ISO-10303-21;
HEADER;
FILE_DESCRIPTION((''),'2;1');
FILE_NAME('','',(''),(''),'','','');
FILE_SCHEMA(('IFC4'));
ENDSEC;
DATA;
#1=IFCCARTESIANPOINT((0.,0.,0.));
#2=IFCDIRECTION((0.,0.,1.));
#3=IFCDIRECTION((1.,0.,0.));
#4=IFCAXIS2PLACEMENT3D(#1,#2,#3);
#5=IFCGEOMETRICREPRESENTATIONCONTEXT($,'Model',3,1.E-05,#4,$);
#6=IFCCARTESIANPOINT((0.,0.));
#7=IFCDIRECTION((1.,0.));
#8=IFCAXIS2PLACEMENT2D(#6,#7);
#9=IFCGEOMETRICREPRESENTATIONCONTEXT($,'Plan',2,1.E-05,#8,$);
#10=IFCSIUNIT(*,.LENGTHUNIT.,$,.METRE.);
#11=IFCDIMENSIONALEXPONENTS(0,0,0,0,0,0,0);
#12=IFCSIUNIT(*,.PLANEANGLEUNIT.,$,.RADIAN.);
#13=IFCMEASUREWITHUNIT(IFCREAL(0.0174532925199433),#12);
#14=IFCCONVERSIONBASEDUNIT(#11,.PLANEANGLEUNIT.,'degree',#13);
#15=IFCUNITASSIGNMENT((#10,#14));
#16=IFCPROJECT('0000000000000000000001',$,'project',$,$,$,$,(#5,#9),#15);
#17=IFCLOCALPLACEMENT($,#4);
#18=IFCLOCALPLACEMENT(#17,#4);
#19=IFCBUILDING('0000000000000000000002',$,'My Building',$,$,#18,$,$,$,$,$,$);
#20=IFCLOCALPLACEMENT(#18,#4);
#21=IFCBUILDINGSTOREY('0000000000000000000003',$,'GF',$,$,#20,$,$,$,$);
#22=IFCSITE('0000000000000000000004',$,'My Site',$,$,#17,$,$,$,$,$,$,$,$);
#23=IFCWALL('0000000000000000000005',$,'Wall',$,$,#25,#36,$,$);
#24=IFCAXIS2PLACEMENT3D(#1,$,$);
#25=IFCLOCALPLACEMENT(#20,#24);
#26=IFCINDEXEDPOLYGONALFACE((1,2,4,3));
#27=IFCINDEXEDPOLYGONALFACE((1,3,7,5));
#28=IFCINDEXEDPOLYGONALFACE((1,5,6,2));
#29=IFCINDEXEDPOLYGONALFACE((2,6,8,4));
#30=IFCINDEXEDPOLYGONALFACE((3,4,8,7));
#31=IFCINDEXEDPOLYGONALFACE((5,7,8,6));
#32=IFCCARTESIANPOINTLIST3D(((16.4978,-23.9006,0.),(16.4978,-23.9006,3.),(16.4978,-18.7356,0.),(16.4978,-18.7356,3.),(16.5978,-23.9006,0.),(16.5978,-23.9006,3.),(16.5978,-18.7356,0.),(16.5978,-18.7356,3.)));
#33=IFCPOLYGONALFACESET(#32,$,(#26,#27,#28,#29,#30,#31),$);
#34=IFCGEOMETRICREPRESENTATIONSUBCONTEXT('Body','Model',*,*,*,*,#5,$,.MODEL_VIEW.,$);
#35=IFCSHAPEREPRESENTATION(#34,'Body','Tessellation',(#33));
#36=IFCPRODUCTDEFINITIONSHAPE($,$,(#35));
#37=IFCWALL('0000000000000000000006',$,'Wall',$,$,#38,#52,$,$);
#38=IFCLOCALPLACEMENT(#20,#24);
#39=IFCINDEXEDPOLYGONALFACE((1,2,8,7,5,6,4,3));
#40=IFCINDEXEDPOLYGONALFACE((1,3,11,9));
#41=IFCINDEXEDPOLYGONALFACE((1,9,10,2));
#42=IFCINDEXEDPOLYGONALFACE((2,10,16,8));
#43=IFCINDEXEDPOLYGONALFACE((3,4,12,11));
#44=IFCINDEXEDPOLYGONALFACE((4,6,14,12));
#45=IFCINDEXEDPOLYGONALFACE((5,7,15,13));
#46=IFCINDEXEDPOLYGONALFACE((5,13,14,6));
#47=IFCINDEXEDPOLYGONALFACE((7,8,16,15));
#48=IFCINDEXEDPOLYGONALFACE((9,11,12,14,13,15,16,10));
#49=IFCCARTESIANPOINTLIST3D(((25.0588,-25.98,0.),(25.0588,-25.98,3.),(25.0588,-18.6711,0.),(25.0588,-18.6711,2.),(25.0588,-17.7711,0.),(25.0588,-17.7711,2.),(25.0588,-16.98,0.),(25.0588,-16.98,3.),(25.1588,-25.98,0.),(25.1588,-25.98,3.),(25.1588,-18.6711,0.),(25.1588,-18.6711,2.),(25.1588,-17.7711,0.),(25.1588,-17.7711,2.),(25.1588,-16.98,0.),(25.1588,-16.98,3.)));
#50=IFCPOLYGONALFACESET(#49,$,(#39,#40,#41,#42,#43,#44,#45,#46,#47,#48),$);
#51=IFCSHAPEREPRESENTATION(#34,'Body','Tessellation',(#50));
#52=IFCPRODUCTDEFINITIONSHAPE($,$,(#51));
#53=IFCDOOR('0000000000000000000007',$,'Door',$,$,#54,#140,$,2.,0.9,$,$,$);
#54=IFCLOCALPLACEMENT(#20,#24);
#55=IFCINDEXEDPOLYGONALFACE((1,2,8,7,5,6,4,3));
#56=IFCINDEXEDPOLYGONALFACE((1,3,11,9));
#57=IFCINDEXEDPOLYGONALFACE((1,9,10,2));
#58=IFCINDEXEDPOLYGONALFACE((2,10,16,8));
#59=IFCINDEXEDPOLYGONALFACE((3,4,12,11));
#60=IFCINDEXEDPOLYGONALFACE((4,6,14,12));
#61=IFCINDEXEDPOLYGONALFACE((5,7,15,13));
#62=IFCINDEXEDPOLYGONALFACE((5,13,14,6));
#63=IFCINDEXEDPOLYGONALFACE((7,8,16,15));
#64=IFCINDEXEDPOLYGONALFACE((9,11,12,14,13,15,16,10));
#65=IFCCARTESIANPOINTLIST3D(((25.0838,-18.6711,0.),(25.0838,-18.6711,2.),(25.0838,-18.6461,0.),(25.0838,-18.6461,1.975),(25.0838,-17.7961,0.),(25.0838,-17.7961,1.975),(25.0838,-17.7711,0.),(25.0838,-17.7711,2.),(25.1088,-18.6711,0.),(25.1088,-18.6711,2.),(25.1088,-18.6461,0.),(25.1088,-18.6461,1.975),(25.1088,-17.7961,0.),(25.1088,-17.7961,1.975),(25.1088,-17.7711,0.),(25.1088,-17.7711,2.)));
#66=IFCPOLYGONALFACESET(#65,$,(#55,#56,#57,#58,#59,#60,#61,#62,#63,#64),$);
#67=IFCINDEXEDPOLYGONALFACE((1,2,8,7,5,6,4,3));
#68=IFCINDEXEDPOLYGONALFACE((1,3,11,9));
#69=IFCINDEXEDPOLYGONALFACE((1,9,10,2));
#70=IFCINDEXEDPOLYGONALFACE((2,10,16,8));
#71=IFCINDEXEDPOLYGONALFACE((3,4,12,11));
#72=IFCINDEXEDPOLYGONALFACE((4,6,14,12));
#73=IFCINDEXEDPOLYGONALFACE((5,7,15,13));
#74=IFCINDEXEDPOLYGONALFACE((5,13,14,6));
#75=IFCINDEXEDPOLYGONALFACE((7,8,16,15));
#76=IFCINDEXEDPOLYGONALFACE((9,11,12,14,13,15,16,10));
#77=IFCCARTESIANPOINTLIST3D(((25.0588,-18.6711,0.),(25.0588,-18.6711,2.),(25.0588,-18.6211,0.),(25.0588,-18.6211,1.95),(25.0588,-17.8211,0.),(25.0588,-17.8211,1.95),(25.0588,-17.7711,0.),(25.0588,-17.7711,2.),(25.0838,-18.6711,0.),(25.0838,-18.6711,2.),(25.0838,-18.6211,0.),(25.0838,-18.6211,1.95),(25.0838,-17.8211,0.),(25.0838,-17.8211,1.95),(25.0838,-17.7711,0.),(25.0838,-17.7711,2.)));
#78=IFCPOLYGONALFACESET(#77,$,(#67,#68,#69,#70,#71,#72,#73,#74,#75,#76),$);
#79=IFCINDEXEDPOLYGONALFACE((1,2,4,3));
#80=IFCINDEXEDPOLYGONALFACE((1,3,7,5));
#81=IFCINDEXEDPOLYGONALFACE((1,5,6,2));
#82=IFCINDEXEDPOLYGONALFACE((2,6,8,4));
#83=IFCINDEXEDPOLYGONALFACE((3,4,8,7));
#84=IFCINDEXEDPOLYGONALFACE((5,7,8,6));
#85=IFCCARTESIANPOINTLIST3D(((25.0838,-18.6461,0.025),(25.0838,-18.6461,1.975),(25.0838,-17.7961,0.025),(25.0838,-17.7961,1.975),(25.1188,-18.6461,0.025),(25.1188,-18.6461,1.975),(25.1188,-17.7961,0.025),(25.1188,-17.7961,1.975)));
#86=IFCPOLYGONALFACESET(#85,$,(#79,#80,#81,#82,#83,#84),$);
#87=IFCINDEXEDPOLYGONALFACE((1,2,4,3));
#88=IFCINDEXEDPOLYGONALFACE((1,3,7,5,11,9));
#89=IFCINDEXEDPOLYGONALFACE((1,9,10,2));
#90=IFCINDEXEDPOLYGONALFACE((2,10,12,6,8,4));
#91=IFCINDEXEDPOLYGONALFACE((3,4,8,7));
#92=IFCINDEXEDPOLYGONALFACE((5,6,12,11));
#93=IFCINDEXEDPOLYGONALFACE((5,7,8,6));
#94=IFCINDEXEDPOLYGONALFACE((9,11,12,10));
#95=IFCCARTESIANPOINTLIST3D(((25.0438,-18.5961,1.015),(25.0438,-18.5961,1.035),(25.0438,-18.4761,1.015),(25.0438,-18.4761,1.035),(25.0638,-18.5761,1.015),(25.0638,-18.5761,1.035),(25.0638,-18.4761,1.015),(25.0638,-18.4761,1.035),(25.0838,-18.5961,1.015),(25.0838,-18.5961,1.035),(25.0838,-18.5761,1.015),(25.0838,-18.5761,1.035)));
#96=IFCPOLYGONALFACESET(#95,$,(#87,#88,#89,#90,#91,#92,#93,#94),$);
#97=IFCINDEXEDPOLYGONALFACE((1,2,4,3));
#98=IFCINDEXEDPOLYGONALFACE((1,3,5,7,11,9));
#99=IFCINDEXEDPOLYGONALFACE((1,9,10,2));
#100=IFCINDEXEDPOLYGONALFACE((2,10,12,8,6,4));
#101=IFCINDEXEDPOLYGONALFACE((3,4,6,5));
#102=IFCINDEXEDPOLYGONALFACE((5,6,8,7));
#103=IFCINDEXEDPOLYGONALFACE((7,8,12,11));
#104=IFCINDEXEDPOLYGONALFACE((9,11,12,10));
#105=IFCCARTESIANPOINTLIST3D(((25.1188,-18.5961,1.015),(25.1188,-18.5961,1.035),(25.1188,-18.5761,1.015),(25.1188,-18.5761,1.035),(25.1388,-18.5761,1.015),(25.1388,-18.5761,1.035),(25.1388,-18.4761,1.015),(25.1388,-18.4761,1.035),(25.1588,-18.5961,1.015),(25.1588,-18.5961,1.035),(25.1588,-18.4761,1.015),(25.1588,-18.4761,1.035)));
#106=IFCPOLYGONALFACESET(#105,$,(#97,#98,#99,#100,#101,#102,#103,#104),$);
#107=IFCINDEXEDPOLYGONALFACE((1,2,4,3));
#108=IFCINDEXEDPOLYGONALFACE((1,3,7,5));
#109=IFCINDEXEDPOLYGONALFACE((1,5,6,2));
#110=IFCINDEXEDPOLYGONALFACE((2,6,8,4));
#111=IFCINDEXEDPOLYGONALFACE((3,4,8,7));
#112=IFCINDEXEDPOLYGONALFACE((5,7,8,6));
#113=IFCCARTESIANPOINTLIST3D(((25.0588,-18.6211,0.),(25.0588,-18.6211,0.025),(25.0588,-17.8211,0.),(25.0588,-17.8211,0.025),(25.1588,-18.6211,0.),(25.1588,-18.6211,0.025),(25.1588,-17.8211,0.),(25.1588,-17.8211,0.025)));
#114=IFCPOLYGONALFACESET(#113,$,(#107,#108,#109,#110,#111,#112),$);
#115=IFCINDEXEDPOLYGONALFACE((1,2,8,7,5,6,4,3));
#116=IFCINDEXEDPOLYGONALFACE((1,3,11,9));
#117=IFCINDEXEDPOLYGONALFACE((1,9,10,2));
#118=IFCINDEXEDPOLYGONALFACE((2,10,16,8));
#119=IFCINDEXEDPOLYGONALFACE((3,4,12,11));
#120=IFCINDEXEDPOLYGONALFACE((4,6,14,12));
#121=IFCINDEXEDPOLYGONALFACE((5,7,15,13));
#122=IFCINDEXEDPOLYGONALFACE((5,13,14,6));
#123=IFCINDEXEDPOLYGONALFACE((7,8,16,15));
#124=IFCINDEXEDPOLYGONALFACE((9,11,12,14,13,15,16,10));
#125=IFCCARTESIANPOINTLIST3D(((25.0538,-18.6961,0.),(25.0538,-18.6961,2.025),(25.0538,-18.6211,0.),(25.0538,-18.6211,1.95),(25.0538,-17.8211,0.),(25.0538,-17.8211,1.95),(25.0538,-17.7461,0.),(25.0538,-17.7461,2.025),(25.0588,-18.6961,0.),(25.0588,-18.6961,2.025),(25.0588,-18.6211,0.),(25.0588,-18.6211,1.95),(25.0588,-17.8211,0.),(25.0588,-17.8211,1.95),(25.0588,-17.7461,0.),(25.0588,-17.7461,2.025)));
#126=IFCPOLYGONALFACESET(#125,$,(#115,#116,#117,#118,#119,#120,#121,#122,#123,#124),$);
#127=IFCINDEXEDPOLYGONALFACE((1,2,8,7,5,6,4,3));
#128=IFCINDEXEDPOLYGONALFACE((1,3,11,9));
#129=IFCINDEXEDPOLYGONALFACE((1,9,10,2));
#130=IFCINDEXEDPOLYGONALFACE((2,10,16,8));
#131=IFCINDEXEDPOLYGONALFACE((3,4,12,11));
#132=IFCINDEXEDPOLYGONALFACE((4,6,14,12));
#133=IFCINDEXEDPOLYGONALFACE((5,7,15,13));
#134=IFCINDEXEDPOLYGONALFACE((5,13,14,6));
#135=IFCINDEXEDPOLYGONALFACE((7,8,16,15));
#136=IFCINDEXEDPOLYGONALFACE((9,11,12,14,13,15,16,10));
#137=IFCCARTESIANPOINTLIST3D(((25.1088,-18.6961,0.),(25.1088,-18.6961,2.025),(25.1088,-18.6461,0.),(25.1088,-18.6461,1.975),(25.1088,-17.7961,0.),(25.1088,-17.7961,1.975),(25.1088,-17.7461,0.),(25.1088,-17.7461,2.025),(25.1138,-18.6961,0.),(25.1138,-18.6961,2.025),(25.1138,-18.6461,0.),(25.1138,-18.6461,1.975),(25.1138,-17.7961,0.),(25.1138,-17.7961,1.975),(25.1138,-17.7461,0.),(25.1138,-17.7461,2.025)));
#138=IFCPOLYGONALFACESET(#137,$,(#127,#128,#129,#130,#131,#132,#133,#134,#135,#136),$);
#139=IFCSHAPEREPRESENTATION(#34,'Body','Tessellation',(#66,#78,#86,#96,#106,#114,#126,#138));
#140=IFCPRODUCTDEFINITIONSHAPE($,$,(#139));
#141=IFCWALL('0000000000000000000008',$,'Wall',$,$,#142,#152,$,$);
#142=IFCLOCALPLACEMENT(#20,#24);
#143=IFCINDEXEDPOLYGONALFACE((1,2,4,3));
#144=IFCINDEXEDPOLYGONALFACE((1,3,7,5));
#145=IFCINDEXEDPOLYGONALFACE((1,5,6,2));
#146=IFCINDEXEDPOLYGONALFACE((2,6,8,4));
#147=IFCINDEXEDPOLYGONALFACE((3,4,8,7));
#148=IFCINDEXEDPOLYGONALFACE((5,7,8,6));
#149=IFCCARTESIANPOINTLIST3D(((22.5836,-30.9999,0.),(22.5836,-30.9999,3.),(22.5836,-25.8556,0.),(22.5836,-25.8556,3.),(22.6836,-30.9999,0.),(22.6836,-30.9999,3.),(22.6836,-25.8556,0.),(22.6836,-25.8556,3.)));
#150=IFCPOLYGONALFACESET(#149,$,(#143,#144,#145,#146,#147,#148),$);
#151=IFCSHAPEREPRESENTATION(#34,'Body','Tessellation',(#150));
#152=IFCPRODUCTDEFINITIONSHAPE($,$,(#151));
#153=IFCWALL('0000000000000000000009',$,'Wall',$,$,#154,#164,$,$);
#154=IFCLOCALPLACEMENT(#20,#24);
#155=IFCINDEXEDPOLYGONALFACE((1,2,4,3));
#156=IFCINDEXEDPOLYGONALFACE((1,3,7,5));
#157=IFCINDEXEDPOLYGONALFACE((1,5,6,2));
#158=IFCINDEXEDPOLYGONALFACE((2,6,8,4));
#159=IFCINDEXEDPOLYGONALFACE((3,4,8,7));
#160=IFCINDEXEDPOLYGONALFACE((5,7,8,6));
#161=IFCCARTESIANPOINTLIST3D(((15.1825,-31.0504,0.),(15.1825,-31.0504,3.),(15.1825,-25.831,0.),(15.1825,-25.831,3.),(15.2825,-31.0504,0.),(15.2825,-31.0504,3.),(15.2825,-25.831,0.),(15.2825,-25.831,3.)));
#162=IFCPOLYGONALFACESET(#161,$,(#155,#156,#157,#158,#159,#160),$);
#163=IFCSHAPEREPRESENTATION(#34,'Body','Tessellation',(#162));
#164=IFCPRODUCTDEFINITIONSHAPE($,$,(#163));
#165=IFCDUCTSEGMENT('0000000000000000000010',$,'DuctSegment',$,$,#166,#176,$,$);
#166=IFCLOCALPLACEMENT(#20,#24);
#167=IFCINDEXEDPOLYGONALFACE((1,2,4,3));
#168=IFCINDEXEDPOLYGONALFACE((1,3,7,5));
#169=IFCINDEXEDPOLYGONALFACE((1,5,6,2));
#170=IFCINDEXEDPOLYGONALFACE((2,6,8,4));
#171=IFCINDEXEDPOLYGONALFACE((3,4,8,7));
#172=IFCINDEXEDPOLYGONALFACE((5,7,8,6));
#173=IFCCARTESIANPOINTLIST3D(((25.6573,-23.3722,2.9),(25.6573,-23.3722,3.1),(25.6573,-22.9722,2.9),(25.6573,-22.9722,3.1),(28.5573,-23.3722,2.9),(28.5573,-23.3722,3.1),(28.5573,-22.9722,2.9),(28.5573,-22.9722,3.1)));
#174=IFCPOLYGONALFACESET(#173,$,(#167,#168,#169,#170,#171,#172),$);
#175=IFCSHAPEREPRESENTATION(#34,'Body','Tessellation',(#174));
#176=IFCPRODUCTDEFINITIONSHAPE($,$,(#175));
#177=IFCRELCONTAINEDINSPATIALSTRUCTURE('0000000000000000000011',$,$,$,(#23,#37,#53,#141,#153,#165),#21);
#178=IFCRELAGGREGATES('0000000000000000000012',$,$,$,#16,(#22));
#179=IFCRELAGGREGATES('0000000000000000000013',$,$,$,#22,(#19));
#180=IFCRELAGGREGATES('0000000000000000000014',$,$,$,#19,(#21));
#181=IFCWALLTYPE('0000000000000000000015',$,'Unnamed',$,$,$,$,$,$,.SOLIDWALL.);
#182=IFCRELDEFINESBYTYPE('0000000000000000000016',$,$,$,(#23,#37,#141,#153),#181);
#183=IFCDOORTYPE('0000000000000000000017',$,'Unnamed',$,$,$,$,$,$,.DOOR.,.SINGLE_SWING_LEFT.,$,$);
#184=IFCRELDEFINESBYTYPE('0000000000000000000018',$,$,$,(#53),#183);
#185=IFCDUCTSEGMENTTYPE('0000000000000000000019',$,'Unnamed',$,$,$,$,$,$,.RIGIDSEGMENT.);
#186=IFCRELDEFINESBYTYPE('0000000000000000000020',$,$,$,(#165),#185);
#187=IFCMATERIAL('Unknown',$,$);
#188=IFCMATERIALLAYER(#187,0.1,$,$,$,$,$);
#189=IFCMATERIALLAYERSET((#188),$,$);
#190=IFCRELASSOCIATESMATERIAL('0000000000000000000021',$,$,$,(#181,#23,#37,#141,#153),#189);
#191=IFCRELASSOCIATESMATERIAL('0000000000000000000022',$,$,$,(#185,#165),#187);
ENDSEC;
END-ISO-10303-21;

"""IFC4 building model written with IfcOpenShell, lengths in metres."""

from ifc_helpers import new_model, entity, si_unit, converted_unit, frame, origin_with_axes, origin_2d_with_axis, place, context, subcontext, project, spatial, line, indexed_curve, rectangle, outline, extrude, shape, source, transform, mapped, material, layer, layer_set, layer_usage, material_profile, profile_set, profile_usage, type_object, type_shapes, element, fill, save


model = new_model("IFC4")

# Units and contexts
model_context = context("Model", 3, precision=1e-05, world=origin_with_axes())
plan_context = context("Plan", 2, precision=1e-05, world=origin_2d_with_axis())
body_context_1 = subcontext(model_context, "Body", "Model", "MODEL_VIEW")
body_context_2 = subcontext(plan_context, "Body", "Plan", "PLAN_VIEW")
ifc_project = project(units=[si_unit("LENGTHUNIT", "METRE"), converted_unit("PLANEANGLEUNIT", "degree", entity("IfcReal", 0.0174532925199433), si_unit("PLANEANGLEUNIT", "RADIAN"), dimensions=[0, 0, 0, 0, 0, 0, 0])], contexts=[model_context, plan_context])

# Site, building, storey
site_placement = place(None, origin_with_axes())
site = spatial("IfcSite", under=ifc_project, at=site_placement, Name="My Site")
building_placement = place(site_placement, origin_with_axes())
building = spatial("IfcBuilding", under=site, at=building_placement, Name="My Building")
storey_placement = place(building_placement, origin_with_axes())
storey = spatial("IfcBuildingStorey", under=building, at=storey_placement, Name="GF")

# Shared definitions
ifc_material = material(Name="Unknown")
ifc_layer = layer(ifc_material, 0.1)
ifc_layer_set = layer_set([ifc_layer])
wall_type = type_object("IfcWallType", Name="Unnamed", PredefinedType="SOLIDWALL", material=ifc_layer_set)

# Shared definitions
shared_shape_1 = source(origin_with_axes(), body_context_1, "Body", "SweptSolid", [
    extrude(outline(indexed_curve([(0.0, 0.0), (0.9, 0.0), (0.9, 2.0), (0.0, 2.0)], segments=[line(1, 2, 3, 4, 1)])), frame((0.0, -0.6, 0.0), z_axis=(0.0, -1.0, 0.0), x_axis=(1.0, 0.0, 0.0)), (0.0, 0.0, -1.0), 1.2),
])
door_type = type_object("IfcDoorType", Name="Unnamed", OperationType="SINGLE_SWING_LEFT", PredefinedType="DOOR")
shared_shape_2 = source(origin_with_axes(), body_context_1, "Body", "SweptSolid", [
    extrude(outline(indexed_curve([(0.0, 0.0), (0.0, 2.0), (0.9, 2.0), (0.9, 0.0), (0.875, 0.0), (0.875, 1.975), (0.025, 1.975), (0.025, 0.0)], segments=[line(1, 2, 3, 4, 5, 6, 7, 8, 1)])), frame((0.0, 0.025, 0.0), z_axis=(0.0, -1.0, 0.0), x_axis=(1.0, 0.0, 0.0)), (0.0, 0.0, -1.0), 0.025),
    extrude(outline(indexed_curve([(0.0, 0.0), (0.0, 2.0), (0.9, 2.0), (0.9, 0.0), (0.85, 0.0), (0.85, 1.95), (0.05, 1.95), (0.05, 0.0)], segments=[line(1, 2, 3, 4, 5, 6, 7, 8, 1)])), frame((0.0, 0.0, 0.0), z_axis=(0.0, -1.0, 0.0), x_axis=(1.0, 0.0, 0.0)), (0.0, 0.0, -1.0), 0.025),
    extrude(outline(indexed_curve([(0.0, 0.0), (0.85, 0.0), (0.85, 0.035), (0.0, 0.035)], segments=[line(1, 2, 3, 4, 1)])), frame((0.025, 0.025, 0.025), z_axis=(0.0, 0.0, 1.0), x_axis=(1.0, 0.0, 0.0)), (0.0, 0.0, 1.0), 1.95),
    extrude(outline(indexed_curve([(0.0, 0.0), (0.0, -0.04), (-0.12, -0.04), (-0.12, -0.02), (-0.02, -0.02), (-0.02, 0.0)], segments=[line(1, 2, 3, 4, 5, 6, 1)])), frame((0.825, 0.025, 1.015), z_axis=(0.0, 0.0, 1.0), x_axis=(1.0, 0.0, 0.0)), (0.0, 0.0, 1.0), 0.02),
    extrude(outline(indexed_curve([(0.0, 0.0), (0.0, 0.04), (-0.12, 0.04), (-0.12, 0.02), (-0.02, 0.02), (-0.02, 0.0)], segments=[line(1, 2, 3, 4, 5, 6, 1)])), frame((0.825, 0.06, 1.015), z_axis=(0.0, 0.0, 1.0), x_axis=(1.0, 0.0, 0.0)), (0.0, 0.0, 1.0), 0.02),
    extrude(outline(indexed_curve([(0.0, 0.0), (0.8, 0.0), (0.8, 0.1), (0.0, 0.1)], segments=[line(1, 2, 3, 4, 1)])), frame((0.05, 0.0, 0.0), z_axis=(0.0, 0.0, 1.0), x_axis=(1.0, 0.0, 0.0)), (0.0, 0.0, 1.0), 0.025),
    extrude(outline(indexed_curve([(0.0, 0.0), (0.0, 2.025), (0.95, 2.025), (0.95, 0.0), (0.875, 0.0), (0.875, 1.95), (0.075, 1.95), (0.075, 0.0)], segments=[line(1, 2, 3, 4, 5, 6, 7, 8, 1)])), frame((-0.025, -0.005, 0.0), z_axis=(0.0, -1.0, 0.0), x_axis=(1.0, 0.0, 0.0)), (0.0, 0.0, -1.0), 0.005),
    extrude(outline(indexed_curve([(0.0, 0.0), (0.0, 2.025), (0.95, 2.025), (0.95, 0.0), (0.9, 0.0), (0.9, 1.975), (0.05, 1.975), (0.05, 0.0)], segments=[line(1, 2, 3, 4, 5, 6, 7, 8, 1)])), frame((-0.025, 0.05, 0.0), z_axis=(0.0, -1.0, 0.0), x_axis=(1.0, 0.0, 0.0)), (0.0, 0.0, -1.0), 0.005),
])
shared_shape_3 = source(origin_with_axes(), body_context_2, "Body", "Curve2D", [
    entity("IfcIndexedPolyCurve", entity("IfcCartesianPointList2D", [[0.0, 0.0], [0.0, 0.05], [0.025, 0.05], [0.025, 0.025], [0.05, 0.025], [0.05, 0.0]]), [entity("IfcLineIndex", [1, 2, 3, 4, 5, 6, 1])]),
    entity("IfcIndexedPolyCurve", entity("IfcCartesianPointList2D", [[0.9, 0.0], [0.9, 0.05], [0.875, 0.05], [0.875, 0.025], [0.85, 0.025], [0.85, 0.0]]), [entity("IfcLineIndex", [1, 2, 3, 4, 5, 6, 1])]),
    entity("IfcTrimmedCurve", entity("IfcEllipse", entity("IfcAxis2Placement2D", entity("IfcCartesianPoint", [0.06, 0.05]), entity("IfcDirection", [1.0, 0.0])), 0.815, 0.85), [entity("IfcCartesianPoint", [0.875, 0.05])], [entity("IfcCartesianPoint", [0.06, 0.9])], True, "CARTESIAN"),
    entity("IfcIndexedPolyCurve", entity("IfcCartesianPointList2D", [[0.025, 0.05], [0.06, 0.05], [0.06, 0.9], [0.025, 0.9]]), [entity("IfcLineIndex", [1, 2, 3, 4, 1])]),
])
type_shapes(door_type, [shared_shape_2, shared_shape_3])

# Wall
ifc_layer_usage_1 = layer_usage(ifc_layer_set, "AXIS2", "POSITIVE", 0.0)
wall_1_placement = place(storey_placement, frame((16.4978, -18.7356, 0.0), z_axis=(0.0, 0.0, 1.0), x_axis=(0.0, -1.0, 0.0)))
element("IfcWall", 1, at=wall_1_placement, inside=storey, type_object=wall_type, material=ifc_layer_usage_1, Name="Wall", context=body_context_1, shape_type="SweptSolid", body=[
    extrude(outline(indexed_curve([(0.0, 0.0), (0.0, 0.1), (5.1651, 0.1), (5.1651, 0.0)], segments=[line(1, 2, 3, 4, 1)])), origin_with_axes(), (0.0, 0.0, 1.0), 3.0),
])

# Wall, opening, door
ifc_layer_usage_2 = layer_usage(ifc_layer_set, "AXIS2", "POSITIVE", 0.0)
wall_2_placement = place(storey_placement, frame((25.0588, -16.98, 0.0), z_axis=(0.0, 0.0, 1.0), x_axis=(0.0, -1.0, 0.0)))
wall_2 = element("IfcWall", 2, at=wall_2_placement, inside=storey, type_object=wall_type, material=ifc_layer_usage_2, Name="Wall", context=body_context_1, shape_type="SweptSolid", body=[
    extrude(outline(indexed_curve([(0.0, 0.0), (0.0, 0.1), (9.0, 0.1), (9.0, 0.0)], segments=[line(1, 2, 3, 4, 1)])), origin_with_axes(), (0.0, 0.0, 1.0), 3.0),
])
opening_1_placement = place(wall_2_placement, frame((0.7911, 0.0, 0.0), z_axis=(0.0, 0.0, 1.0), x_axis=(1.0, 0.0, 0.0)))
opening_1 = element("IfcOpeningElement", 3, at=opening_1_placement, cuts=wall_2, PredefinedType="OPENING", context=body_context_1, shape_type="MappedRepresentation", body=[
    mapped(shared_shape_1, transform((0.0, 0.0, 0.0), x_axis=(1.0, 0.0, 0.0), y_axis=(0.0, 1.0, 0.0), z_axis=(0.0, 0.0, 1.0), scale=1.0)),
])
door_1_placement = place(opening_1_placement, frame((0.0, 0.0, 0.0), z_axis=(0.0, 0.0, 1.0), x_axis=(1.0, 0.0, 0.0)))
door_1 = element("IfcDoor", 4, at=door_1_placement, inside=storey, type_object=door_type, Name="Door", OverallHeight=2.0, OverallWidth=0.9, shapes=[
    shape(body_context_1, "Body", "MappedRepresentation", [mapped(shared_shape_2, transform((0.0, 0.0, 0.0), x_axis=(1.0, 0.0, 0.0), y_axis=(0.0, 1.0, 0.0), z_axis=(0.0, 0.0, 1.0), scale=1.0))]),
    shape(body_context_2, "Body", "MappedRepresentation", [mapped(shared_shape_3, transform((0.0, 0.0, 0.0), x_axis=(1.0, 0.0, 0.0), y_axis=(0.0, 1.0, 0.0), z_axis=(0.0, 0.0, 1.0), scale=1.0))]),
])
fill(opening_1, door_1)

# Walls
ifc_layer_usage_3 = layer_usage(ifc_layer_set, "AXIS2", "POSITIVE", 0.0)
wall_3_placement = place(storey_placement, frame((22.5836, -25.8556, 0.0), z_axis=(0.0, 0.0, 1.0), x_axis=(0.0, -1.0, 0.0)))
element("IfcWall", 5, at=wall_3_placement, inside=storey, type_object=wall_type, material=ifc_layer_usage_3, Name="Wall", context=body_context_1, shape_type="SweptSolid", body=[
    extrude(outline(indexed_curve([(0.0, 0.0), (0.0, 0.1), (5.1443, 0.1), (5.1443, 0.0)], segments=[line(1, 2, 3, 4, 1)])), origin_with_axes(), (0.0, 0.0, 1.0), 3.0),
])
ifc_layer_usage_4 = layer_usage(ifc_layer_set, "AXIS2", "POSITIVE", 0.0)
wall_4_placement = place(storey_placement, frame((15.1825, -25.831, 0.0), z_axis=(0.0, 0.0, 1.0), x_axis=(0.0, -1.0, 0.0)))
element("IfcWall", 6, at=wall_4_placement, inside=storey, type_object=wall_type, material=ifc_layer_usage_4, Name="Wall", context=body_context_1, shape_type="SweptSolid", body=[
    extrude(outline(indexed_curve([(0.0, 0.0), (0.0, 0.1), (5.2194, 0.1), (5.2194, 0.0)], segments=[line(1, 2, 3, 4, 1)])), origin_with_axes(), (0.0, 0.0, 1.0), 3.0),
])

# Duct segment
ifc_material_profile_1 = material_profile(ifc_material, rectangle(XDim=0.4, YDim=0.2))
ifc_profile_set_1 = profile_set([ifc_material_profile_1])
ifc_profile_usage_1 = profile_usage(ifc_profile_set_1, cardinal=5)
duct_segment_type = type_object("IfcDuctSegmentType", Name="Unnamed", PredefinedType="RIGIDSEGMENT", material=ifc_profile_set_1)
duct_segment_1_placement = place(storey_placement, frame((25.6573, -23.1722, 3.0), z_axis=(1.0, 0.0, 0.0), x_axis=(0.0, 1.0, 0.0)))
element("IfcDuctSegment", 7, at=duct_segment_1_placement, inside=storey, type_object=duct_segment_type, material=ifc_profile_usage_1, Name="DuctSegment", context=body_context_1, shape_type="SweptSolid", body=[
    extrude(rectangle(XDim=0.4, YDim=0.2), origin_with_axes(), (0.0, 0.0, 1.0), 2.9),
])

save(model, "model.ifc")
